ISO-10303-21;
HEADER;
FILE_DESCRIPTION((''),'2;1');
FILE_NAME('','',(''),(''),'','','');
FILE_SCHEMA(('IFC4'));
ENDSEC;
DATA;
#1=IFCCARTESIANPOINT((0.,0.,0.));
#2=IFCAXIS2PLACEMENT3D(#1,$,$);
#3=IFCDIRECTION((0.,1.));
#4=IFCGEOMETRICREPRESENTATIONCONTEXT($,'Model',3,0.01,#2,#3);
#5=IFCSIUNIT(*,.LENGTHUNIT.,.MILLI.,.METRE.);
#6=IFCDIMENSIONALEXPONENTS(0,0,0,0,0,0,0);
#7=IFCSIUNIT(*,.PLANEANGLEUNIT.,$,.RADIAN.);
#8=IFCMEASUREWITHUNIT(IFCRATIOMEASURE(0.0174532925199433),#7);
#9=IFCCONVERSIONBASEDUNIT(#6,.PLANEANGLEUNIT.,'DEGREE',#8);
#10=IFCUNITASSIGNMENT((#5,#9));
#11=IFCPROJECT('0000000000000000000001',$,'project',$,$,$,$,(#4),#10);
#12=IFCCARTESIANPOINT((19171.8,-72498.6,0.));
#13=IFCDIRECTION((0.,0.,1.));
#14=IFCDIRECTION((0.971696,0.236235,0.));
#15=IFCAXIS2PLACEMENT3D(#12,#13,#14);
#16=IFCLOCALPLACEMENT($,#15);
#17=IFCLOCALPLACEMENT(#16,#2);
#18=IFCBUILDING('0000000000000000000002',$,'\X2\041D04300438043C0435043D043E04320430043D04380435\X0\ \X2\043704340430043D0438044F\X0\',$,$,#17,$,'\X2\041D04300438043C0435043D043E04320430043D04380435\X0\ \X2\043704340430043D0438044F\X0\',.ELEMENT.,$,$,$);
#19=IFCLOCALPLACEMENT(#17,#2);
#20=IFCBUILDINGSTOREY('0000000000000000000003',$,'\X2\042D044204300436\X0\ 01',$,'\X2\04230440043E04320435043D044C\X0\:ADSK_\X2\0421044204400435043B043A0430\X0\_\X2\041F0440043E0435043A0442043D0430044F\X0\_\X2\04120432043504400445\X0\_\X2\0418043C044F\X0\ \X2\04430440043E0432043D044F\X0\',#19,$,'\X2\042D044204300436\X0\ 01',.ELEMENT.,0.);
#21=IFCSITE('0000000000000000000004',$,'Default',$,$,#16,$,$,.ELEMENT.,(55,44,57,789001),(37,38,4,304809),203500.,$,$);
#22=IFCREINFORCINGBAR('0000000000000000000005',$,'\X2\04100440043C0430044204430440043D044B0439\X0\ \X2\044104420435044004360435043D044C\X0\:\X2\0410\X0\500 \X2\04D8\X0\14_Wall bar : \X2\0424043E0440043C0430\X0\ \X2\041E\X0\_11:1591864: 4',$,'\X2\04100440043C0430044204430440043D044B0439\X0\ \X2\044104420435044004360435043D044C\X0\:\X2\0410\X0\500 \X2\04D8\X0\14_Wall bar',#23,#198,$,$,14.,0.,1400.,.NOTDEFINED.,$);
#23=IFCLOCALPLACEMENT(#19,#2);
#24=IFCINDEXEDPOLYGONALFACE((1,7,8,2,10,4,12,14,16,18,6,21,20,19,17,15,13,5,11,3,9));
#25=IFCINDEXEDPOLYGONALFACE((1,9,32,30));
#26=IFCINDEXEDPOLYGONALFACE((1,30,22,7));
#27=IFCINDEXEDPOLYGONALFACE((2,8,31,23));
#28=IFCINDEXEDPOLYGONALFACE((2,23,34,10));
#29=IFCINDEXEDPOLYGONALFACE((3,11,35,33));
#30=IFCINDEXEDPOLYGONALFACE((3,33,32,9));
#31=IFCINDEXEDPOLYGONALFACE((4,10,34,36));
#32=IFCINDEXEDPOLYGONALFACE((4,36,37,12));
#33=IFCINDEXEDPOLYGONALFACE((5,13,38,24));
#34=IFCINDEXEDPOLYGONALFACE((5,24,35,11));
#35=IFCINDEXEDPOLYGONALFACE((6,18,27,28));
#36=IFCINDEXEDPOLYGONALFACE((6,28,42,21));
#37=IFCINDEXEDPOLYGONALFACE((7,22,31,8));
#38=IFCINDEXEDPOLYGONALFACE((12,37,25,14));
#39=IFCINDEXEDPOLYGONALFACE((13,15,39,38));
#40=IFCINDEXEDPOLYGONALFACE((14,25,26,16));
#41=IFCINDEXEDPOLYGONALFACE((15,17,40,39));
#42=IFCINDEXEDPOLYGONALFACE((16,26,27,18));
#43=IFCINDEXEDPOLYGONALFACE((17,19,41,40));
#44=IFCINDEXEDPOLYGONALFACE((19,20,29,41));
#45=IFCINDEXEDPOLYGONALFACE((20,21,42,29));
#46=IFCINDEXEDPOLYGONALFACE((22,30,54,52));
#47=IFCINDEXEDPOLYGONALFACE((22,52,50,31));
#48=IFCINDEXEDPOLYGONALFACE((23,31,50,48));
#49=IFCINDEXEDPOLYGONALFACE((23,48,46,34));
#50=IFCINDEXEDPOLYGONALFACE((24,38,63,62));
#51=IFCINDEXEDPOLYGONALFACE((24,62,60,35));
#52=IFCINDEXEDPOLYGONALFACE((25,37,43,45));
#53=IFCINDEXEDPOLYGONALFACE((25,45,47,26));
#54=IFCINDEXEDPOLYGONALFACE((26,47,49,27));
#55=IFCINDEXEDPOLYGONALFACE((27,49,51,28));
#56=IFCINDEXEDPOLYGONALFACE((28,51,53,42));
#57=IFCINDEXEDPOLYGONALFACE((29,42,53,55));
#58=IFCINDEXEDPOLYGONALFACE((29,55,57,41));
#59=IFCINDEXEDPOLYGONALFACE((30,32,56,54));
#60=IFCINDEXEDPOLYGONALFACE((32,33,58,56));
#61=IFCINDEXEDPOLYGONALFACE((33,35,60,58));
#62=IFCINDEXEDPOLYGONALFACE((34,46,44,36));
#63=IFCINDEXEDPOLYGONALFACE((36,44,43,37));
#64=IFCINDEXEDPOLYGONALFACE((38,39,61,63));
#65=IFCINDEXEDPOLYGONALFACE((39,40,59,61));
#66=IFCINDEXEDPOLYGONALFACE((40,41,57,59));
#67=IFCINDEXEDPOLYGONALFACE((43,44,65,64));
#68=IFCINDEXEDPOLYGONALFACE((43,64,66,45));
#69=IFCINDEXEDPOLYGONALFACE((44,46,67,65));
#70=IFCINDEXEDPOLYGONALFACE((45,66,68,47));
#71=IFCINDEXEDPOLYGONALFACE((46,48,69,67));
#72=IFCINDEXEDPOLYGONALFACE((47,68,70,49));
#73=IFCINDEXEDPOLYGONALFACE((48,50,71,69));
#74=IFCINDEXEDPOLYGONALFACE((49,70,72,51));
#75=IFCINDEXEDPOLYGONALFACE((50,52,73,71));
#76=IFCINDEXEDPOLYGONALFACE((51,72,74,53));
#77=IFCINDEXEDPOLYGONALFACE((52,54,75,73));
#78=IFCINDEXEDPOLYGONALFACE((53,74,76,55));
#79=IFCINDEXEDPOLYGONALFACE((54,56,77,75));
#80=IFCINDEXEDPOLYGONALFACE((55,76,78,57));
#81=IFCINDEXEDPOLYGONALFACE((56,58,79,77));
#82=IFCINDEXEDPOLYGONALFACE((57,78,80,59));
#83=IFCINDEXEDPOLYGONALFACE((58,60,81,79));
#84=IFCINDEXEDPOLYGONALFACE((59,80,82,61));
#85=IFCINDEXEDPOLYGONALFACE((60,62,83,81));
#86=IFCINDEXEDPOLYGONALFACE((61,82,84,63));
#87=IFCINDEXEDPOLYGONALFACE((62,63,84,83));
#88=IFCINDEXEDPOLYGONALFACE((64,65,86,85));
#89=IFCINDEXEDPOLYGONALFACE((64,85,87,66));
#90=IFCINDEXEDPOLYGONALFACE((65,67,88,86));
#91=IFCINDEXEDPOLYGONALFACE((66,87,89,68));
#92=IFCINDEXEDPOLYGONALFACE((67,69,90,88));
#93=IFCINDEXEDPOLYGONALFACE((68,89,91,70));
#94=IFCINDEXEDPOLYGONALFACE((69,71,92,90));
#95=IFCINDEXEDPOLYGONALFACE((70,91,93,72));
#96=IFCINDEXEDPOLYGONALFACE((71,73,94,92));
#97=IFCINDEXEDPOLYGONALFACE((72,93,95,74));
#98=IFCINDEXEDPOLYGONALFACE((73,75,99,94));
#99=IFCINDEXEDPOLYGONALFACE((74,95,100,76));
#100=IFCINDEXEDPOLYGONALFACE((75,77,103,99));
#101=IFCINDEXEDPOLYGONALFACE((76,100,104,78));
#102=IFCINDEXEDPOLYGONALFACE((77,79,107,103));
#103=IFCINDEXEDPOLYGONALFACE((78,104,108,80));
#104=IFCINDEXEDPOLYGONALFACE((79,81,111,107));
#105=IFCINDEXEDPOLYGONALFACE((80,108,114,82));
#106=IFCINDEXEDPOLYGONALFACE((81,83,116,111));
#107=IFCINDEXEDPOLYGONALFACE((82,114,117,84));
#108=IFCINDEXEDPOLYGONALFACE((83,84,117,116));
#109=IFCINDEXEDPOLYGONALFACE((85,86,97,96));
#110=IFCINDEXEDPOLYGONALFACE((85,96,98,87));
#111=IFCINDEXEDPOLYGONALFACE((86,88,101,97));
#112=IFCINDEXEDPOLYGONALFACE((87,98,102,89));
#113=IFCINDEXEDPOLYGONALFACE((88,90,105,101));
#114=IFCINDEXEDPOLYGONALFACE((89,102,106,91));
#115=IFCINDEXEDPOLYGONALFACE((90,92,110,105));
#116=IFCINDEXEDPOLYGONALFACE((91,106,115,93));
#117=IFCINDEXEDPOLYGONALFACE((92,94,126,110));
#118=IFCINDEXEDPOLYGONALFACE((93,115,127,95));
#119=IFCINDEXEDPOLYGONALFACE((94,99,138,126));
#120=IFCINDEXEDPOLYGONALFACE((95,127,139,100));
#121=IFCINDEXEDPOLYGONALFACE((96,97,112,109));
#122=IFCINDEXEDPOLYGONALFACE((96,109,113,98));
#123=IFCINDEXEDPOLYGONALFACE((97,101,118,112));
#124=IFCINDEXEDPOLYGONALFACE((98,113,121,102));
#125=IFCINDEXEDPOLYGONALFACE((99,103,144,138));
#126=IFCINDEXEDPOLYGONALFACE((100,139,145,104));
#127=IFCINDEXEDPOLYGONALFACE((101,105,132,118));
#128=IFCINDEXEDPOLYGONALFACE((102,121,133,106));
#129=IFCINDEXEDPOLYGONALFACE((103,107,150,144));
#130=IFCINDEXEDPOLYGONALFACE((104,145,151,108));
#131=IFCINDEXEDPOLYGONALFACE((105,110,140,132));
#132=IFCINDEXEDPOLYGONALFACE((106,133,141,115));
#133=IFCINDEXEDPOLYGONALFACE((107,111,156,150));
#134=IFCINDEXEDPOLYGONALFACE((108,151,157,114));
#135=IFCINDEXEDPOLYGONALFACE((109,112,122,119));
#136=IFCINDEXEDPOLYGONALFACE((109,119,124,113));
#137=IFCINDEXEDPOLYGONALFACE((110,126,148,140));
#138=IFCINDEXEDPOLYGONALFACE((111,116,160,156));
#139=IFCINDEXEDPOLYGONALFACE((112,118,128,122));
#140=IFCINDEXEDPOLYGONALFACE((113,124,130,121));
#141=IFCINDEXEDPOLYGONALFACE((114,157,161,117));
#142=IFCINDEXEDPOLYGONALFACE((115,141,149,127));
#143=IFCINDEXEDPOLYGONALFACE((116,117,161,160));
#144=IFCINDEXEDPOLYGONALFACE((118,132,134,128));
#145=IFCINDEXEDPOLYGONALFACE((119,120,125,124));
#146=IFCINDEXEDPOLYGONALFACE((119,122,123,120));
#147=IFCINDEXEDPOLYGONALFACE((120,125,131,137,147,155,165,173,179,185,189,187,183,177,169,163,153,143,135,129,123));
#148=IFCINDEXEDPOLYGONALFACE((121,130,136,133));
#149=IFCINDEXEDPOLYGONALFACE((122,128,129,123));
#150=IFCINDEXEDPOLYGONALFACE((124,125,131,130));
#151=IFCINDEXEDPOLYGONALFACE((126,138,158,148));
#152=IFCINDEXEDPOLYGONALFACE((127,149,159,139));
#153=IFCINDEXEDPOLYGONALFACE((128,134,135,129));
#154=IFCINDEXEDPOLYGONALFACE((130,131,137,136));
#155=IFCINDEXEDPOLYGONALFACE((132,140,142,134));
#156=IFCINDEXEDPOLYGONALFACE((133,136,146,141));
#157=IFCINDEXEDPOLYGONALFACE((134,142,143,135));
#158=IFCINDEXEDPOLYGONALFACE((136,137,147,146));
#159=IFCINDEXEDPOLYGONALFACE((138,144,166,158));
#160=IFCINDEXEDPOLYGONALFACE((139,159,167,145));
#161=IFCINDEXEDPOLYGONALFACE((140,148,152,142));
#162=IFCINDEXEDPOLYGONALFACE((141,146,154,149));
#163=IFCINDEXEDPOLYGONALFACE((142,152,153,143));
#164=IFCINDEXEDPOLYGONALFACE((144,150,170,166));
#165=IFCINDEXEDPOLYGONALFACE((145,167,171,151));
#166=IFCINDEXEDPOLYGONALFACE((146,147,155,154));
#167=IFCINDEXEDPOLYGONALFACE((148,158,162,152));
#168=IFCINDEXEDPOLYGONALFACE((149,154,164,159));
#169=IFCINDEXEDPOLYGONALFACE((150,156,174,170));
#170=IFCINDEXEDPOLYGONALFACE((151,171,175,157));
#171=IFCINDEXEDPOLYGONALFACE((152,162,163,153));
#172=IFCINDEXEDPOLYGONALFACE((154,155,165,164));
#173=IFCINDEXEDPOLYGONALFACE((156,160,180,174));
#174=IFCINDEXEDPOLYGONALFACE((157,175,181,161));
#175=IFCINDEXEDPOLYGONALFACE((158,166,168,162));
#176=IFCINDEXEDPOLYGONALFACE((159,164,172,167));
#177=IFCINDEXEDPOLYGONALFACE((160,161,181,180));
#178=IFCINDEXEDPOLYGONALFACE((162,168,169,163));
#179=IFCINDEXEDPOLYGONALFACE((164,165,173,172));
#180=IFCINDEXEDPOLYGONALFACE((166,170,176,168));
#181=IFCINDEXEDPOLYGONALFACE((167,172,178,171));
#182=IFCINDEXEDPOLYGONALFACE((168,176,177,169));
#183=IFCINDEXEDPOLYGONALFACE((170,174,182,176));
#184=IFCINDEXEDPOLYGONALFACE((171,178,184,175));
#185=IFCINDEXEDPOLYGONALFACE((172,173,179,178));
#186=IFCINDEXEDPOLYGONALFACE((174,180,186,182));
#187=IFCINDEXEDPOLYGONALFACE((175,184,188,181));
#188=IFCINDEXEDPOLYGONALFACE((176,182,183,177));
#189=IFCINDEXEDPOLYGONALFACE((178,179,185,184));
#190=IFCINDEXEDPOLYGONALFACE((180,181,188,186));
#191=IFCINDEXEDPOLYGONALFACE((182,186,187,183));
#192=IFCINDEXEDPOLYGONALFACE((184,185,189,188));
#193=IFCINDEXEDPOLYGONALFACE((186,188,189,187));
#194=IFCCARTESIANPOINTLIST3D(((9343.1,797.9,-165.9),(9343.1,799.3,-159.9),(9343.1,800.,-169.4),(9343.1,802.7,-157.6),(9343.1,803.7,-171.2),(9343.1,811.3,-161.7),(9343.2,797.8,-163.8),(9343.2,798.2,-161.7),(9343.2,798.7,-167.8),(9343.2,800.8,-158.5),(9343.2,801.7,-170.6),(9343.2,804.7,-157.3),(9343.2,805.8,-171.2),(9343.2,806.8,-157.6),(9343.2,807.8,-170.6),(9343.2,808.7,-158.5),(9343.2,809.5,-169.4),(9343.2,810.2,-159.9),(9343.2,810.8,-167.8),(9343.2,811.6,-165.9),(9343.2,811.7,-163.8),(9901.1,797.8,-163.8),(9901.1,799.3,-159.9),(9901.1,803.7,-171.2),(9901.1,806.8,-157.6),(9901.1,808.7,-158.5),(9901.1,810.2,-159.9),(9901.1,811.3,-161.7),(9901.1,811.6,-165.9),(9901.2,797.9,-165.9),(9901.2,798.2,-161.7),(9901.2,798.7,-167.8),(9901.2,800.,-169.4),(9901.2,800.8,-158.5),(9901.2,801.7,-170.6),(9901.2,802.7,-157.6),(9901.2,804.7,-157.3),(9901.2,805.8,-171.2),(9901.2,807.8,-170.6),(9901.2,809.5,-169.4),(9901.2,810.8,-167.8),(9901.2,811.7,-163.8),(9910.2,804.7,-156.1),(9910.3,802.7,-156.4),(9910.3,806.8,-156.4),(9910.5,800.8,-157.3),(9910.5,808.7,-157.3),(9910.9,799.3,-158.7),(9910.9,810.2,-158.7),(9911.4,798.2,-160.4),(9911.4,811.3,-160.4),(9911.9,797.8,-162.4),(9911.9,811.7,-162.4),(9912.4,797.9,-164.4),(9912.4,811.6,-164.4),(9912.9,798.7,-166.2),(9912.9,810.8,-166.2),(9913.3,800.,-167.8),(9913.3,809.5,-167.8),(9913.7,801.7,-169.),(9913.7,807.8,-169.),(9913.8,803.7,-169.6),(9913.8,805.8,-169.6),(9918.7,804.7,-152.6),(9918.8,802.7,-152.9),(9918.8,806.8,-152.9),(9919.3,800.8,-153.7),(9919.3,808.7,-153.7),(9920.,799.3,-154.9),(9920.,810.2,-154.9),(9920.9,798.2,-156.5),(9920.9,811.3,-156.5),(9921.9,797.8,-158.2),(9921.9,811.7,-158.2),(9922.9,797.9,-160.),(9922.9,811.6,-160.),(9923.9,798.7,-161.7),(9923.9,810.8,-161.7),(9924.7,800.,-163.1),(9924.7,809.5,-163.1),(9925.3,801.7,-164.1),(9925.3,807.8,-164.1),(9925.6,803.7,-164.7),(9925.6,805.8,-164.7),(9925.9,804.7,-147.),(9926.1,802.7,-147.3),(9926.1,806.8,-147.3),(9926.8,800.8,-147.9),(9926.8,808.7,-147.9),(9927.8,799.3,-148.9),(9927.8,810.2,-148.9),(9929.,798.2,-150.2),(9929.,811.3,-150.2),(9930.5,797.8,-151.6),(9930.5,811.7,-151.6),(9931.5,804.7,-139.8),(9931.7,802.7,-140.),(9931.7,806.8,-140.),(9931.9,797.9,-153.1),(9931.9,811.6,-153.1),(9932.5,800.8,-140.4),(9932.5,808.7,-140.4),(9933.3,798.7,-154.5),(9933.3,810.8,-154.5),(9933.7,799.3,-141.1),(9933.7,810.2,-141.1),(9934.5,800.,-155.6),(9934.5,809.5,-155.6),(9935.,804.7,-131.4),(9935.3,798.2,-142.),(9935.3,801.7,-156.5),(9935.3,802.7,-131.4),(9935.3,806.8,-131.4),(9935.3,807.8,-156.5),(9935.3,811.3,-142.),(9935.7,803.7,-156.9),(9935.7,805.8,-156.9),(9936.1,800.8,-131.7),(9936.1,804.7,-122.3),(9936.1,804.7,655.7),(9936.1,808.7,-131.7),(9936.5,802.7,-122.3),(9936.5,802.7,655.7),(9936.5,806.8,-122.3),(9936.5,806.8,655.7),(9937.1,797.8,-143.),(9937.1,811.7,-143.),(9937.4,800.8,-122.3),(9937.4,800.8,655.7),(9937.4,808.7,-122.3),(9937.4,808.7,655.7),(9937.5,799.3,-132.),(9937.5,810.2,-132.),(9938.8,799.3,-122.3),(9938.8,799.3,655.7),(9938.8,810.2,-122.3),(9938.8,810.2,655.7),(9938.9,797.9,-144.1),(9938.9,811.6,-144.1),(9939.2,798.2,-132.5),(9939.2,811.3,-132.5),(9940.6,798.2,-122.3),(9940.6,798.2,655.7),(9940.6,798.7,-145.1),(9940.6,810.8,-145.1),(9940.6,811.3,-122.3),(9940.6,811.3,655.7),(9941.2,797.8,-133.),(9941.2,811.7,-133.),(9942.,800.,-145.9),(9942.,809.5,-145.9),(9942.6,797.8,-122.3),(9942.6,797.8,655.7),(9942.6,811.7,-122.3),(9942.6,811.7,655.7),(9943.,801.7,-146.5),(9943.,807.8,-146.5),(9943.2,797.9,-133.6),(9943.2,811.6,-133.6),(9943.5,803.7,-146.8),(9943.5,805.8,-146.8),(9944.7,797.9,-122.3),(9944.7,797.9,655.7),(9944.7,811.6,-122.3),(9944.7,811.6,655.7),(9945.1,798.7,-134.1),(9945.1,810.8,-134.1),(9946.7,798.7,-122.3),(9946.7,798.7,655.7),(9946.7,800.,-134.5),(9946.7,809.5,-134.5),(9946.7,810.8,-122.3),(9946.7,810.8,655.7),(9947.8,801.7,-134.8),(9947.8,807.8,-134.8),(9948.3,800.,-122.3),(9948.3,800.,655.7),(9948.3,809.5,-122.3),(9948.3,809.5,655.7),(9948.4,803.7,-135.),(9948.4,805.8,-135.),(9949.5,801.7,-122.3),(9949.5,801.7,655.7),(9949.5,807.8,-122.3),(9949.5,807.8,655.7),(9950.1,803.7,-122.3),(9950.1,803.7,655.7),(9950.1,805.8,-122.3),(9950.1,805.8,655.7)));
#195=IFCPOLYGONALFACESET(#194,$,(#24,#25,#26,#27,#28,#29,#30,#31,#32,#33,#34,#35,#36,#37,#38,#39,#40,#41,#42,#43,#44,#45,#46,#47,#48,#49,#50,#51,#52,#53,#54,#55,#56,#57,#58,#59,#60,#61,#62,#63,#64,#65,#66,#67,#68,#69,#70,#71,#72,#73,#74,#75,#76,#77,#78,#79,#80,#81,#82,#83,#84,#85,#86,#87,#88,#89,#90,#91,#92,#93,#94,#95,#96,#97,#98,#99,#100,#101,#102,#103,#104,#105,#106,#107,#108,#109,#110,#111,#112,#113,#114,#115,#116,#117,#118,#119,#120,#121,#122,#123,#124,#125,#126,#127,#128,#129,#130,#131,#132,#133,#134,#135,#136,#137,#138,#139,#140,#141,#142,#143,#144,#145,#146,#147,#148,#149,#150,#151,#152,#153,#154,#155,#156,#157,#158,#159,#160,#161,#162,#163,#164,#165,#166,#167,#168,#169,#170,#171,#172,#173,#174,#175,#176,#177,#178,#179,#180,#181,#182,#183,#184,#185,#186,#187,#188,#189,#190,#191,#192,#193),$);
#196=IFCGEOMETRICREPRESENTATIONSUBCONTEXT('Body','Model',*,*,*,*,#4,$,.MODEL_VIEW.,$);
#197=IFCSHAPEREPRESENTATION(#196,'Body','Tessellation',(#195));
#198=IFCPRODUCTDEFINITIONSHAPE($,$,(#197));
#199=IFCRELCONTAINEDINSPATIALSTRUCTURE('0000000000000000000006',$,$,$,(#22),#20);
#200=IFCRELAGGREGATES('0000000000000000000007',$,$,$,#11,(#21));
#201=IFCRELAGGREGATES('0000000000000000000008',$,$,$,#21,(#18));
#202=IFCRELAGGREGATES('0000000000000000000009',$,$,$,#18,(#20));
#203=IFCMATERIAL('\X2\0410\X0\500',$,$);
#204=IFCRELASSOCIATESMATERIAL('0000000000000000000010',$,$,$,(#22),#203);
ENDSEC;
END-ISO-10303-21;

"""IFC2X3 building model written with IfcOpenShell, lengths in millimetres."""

from ifc_helpers import new_model, entity, si_unit, converted_unit, direction, frame, origin, place, context, subcontext, project, spatial, material, element, save


model = new_model("IFC2X3")

# Units and contexts
model_context = context("Model", 3, precision=0.01, world=origin(), true_north=direction((0.0, 1.0)))
body_context = subcontext(model_context, "Body", "Model", "MODEL_VIEW")
ifc_project = project(units=[si_unit("LENGTHUNIT", "METRE", prefix="MILLI"), converted_unit("PLANEANGLEUNIT", "DEGREE", entity("IfcRatioMeasure", 0.0174532925199433), si_unit("PLANEANGLEUNIT", "RADIAN"), dimensions=[0, 0, 0, 0, 0, 0, 0])], contexts=[model_context])

# Site, building, storey
site_placement = place(None, frame((19171.8, -72498.6, 0.0), z_axis=(0.0, 0.0, 1.0), x_axis=(0.971696, 0.236235, 0.0)))
site = spatial("IfcSite", under=ifc_project, at=site_placement, Name="Default", CompositionType="ELEMENT", RefLatitude=(55, 44, 57, 789001), RefLongitude=(37, 38, 4, 304809), RefElevation=203500.0)
building_placement = place(site_placement, origin())
building = spatial("IfcBuilding", under=site, at=building_placement, Name="Наименование здания", LongName="Наименование здания", CompositionType="ELEMENT")
storey_placement = place(building_placement, origin())
storey = spatial("IfcBuildingStorey", under=building, at=storey_placement, Name="Этаж 01", ObjectType="Уровень:ADSK_Стрелка_Проектная_Вверх_Имя уровня", LongName="Этаж 01", CompositionType="ELEMENT", Elevation=0.0)

# Reinforcing bar
ifc_material = material(Name="А500")
placement = place(storey_placement, origin())
element("IfcReinforcingBar", 1, at=placement, inside=storey, material=ifc_material, Name="Арматурный стержень:А500 Ә14_Wall bar : Форма О_11:1591864: 4", ObjectType="Арматурный стержень:А500 Ә14_Wall bar", BarLength=1400.0, BarRole="NOTDEFINED", CrossSectionArea=0.0, NominalDiameter=14.0, context=body_context, shape_type="AdvancedSweptSolid", body=[
    entity("IfcSweptDiskSolid", entity("IfcCompositeCurve", [entity("IfcCompositeCurveSegment", "CONTINUOUS", True, entity("IfcPolyline", [entity("IfcCartesianPoint", [9943.1, 804.7, 655.7]), entity("IfcCartesianPoint", [9943.1, 804.7, -122.3])])), entity("IfcCompositeCurveSegment", "CONTINUOUS", True, entity("IfcTrimmedCurve", entity("IfcCircle", entity("IfcAxis2Placement3D", entity("IfcCartesianPoint", [9901.1, 804.7, -122.3]), entity("IfcDirection", [0.0, 1.0, 0.0]), entity("IfcDirection", [0.0, 0.0, -1.0])), 42.0), [entity("IfcParameterValue", 270.0)], [entity("IfcParameterValue", 360.0)], True, "PARAMETER")), entity("IfcCompositeCurveSegment", "CONTINUOUS", True, entity("IfcPolyline", [entity("IfcCartesianPoint", [9901.1, 804.7, -164.3]), entity("IfcCartesianPoint", [9343.1, 804.7, -164.3])]))], False), 7.0, None, 0.0, 92.0),
])

save(model, "model.ifc")
